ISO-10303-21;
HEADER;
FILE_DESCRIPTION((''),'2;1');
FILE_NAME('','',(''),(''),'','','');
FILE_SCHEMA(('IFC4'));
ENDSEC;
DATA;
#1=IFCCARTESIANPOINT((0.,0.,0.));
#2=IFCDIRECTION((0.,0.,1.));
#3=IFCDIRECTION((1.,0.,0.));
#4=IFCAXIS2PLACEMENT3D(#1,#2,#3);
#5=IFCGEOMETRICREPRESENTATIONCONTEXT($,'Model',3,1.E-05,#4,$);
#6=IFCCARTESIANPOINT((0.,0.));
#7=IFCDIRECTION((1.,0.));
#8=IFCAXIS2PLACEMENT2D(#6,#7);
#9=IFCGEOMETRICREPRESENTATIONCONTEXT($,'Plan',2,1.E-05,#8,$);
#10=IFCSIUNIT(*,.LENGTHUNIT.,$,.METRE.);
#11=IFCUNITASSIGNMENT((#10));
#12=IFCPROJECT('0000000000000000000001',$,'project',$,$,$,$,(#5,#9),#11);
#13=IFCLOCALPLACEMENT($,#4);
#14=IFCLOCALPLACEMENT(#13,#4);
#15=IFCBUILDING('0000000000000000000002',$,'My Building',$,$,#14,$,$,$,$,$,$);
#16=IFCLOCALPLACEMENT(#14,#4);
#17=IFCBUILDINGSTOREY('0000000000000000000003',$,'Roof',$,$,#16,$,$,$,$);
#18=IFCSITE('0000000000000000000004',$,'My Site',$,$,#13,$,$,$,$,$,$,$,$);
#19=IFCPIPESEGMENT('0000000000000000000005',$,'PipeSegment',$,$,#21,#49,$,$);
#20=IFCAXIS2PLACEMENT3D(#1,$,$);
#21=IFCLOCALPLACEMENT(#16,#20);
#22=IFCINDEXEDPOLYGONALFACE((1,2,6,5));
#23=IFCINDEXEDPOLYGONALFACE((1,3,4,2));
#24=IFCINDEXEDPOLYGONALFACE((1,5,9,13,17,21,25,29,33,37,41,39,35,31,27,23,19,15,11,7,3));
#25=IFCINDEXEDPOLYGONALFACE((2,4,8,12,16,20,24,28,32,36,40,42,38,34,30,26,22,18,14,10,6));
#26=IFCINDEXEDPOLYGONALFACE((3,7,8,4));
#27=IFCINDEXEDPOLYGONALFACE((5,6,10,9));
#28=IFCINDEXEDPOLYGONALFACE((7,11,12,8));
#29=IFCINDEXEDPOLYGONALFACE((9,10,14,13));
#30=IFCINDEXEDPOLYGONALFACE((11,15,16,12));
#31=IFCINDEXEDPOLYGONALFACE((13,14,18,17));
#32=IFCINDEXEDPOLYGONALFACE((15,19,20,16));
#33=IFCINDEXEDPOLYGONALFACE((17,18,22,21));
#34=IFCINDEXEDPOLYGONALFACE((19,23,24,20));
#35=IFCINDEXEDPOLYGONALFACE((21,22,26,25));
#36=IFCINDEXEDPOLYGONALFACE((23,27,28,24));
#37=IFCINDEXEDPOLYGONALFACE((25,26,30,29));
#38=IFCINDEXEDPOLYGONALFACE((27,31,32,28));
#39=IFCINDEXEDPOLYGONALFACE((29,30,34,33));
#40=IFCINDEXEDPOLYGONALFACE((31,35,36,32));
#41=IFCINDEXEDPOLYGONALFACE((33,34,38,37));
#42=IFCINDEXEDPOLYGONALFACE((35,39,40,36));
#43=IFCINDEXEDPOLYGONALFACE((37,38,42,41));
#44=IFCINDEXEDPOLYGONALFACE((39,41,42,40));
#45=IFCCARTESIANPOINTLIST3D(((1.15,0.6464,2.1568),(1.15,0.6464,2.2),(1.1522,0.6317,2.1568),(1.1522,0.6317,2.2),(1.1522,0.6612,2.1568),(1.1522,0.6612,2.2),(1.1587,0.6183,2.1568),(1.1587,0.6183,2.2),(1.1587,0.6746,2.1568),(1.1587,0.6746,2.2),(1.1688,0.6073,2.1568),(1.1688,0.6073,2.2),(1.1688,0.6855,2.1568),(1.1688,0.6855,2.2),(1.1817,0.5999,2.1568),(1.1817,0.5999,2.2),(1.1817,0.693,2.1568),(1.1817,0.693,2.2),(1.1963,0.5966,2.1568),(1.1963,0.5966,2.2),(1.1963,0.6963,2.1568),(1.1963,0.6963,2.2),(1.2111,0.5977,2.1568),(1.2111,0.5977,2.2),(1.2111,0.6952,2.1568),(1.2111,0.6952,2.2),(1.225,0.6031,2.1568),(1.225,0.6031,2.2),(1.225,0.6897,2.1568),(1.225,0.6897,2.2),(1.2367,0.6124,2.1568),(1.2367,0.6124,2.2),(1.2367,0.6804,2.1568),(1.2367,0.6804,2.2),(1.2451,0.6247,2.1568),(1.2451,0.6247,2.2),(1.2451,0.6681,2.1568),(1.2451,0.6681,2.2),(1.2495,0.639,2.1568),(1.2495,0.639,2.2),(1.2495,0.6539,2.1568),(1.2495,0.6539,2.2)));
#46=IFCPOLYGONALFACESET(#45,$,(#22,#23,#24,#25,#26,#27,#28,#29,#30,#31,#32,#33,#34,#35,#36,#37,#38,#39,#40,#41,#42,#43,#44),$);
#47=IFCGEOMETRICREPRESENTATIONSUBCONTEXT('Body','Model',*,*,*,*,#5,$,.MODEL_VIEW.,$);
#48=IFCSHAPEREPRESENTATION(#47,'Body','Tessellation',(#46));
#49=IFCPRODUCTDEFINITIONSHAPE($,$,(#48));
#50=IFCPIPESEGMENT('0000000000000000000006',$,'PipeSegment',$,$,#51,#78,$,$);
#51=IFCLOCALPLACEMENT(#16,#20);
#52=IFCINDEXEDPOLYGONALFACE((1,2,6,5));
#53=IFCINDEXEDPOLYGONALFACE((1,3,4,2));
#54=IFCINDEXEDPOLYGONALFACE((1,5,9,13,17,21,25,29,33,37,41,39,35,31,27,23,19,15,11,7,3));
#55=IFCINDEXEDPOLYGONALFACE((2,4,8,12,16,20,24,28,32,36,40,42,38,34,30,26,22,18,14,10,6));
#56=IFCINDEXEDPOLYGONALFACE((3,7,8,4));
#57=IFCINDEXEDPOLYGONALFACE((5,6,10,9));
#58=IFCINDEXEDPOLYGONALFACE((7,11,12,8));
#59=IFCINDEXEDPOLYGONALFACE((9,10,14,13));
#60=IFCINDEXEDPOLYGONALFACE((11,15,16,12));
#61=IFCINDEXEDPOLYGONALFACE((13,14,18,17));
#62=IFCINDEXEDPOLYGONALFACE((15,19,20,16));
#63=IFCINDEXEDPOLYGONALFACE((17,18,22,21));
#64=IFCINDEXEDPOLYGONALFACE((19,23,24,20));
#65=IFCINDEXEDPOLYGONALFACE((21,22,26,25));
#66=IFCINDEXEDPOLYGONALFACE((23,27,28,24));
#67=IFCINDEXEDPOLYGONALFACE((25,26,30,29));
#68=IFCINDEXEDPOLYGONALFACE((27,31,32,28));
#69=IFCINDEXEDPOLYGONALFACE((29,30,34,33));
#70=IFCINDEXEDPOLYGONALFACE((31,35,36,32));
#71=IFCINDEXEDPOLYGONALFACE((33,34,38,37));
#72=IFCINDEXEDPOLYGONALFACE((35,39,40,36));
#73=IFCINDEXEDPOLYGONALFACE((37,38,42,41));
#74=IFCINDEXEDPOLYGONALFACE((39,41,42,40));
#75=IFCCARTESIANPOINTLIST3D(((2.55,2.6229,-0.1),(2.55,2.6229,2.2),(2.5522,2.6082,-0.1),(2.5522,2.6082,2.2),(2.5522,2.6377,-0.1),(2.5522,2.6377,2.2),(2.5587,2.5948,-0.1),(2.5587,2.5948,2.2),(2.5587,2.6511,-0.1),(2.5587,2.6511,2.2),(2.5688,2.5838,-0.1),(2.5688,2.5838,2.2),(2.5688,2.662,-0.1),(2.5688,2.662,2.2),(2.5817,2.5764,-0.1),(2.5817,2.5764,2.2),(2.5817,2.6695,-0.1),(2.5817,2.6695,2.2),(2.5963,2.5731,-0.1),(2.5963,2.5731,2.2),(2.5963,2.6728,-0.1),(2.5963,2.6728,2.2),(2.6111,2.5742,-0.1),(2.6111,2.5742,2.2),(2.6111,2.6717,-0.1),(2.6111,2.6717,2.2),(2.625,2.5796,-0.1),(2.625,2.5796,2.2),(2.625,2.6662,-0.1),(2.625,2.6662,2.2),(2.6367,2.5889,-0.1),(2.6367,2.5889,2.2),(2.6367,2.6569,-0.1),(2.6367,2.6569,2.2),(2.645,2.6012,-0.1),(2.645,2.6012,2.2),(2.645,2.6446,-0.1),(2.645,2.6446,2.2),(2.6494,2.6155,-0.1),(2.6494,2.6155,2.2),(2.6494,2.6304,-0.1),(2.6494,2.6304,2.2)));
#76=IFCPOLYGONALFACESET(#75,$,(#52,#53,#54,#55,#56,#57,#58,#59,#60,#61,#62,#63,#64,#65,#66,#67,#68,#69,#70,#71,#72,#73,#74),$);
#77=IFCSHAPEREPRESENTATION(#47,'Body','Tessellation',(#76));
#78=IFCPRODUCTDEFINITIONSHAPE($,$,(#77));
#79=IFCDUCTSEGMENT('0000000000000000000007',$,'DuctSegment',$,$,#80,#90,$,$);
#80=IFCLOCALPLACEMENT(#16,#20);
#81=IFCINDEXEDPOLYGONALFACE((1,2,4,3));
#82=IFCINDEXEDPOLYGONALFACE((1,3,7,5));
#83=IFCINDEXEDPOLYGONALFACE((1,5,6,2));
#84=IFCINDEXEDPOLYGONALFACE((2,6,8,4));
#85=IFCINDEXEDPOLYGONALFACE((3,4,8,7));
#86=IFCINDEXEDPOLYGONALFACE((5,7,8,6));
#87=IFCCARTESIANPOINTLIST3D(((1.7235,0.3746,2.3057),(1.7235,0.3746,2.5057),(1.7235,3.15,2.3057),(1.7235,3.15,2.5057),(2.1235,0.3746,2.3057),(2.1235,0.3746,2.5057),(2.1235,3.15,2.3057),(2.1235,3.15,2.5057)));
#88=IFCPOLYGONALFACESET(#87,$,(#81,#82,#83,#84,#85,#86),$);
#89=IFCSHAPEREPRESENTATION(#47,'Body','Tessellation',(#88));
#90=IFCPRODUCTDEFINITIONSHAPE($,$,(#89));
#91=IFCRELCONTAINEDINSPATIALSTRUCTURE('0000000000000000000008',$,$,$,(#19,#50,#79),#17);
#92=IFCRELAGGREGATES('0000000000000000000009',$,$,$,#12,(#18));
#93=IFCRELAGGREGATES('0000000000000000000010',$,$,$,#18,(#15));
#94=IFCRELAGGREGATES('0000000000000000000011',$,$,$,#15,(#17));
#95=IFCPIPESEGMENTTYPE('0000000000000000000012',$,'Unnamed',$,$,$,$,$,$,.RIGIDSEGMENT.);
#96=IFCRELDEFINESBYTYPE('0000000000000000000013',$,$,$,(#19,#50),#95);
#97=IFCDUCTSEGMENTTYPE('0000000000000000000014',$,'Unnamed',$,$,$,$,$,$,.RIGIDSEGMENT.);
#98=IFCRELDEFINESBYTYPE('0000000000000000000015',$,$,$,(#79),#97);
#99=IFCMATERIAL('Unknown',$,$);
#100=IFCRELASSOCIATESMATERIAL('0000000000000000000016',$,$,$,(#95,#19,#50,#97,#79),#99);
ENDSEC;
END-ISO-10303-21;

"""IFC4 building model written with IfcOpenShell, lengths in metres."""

from ifc_helpers import new_model, si_unit, frame, origin_with_axes, origin_2d_with_axis, place, context, subcontext, project, spatial, rectangle, circle, extrude, material, material_profile, profile_set, profile_usage, type_object, element, save


model = new_model("IFC4")

# Units and contexts
model_context = context("Model", 3, precision=1e-05, world=origin_with_axes())
plan_context = context("Plan", 2, precision=1e-05, world=origin_2d_with_axis())
body_context = subcontext(model_context, "Body", "Model", "MODEL_VIEW")
ifc_project = project(units=[si_unit("LENGTHUNIT", "METRE")], contexts=[model_context, plan_context])

# Site, building, storey
site_placement = place(None, origin_with_axes())
site = spatial("IfcSite", under=ifc_project, at=site_placement, Name="My Site")
building_placement = place(site_placement, origin_with_axes())
building = spatial("IfcBuilding", under=site, at=building_placement, Name="My Building")
storey_placement = place(building_placement, origin_with_axes())
storey = spatial("IfcBuildingStorey", under=building, at=storey_placement, Name="Roof")

# Shared definitions
ifc_material = material(Name="Unknown")

# Pipe segments
ifc_material_profile_1 = material_profile(ifc_material, circle(Radius=0.05))
ifc_profile_set_1 = profile_set([ifc_material_profile_1])
pipe_segment_type = type_object("IfcPipeSegmentType", Name="Unnamed", PredefinedType="RIGIDSEGMENT", material=ifc_profile_set_1)
ifc_profile_usage_1 = profile_usage(ifc_profile_set_1, cardinal=5)
pipe_segment_1_placement = place(storey_placement, frame((1.2, 0.6464, 2.2), z_axis=(0.0, 0.0, -1.0), x_axis=(-1.0, 0.0, 0.0)))
element("IfcPipeSegment", 1, at=pipe_segment_1_placement, inside=storey, type_object=pipe_segment_type, material=ifc_profile_usage_1, Name="PipeSegment", context=body_context, shape_type="SweptSolid", body=[
    extrude(circle(Radius=0.05), origin_with_axes(), (0.0, 0.0, 1.0), 0.0432),
])
ifc_profile_usage_2 = profile_usage(ifc_profile_set_1, cardinal=5)
pipe_segment_2_placement = place(storey_placement, frame((2.6, 2.6229, 2.2), z_axis=(0.0, 0.0, -1.0), x_axis=(-1.0, 0.0, 0.0)))
element("IfcPipeSegment", 2, at=pipe_segment_2_placement, inside=storey, type_object=pipe_segment_type, material=ifc_profile_usage_2, Name="PipeSegment", context=body_context, shape_type="SweptSolid", body=[
    extrude(circle(Radius=0.05), origin_with_axes(), (0.0, 0.0, 1.0), 2.3),
])

# Duct segment
ifc_material_profile_2 = material_profile(ifc_material, rectangle(XDim=0.4, YDim=0.2))
ifc_profile_set_2 = profile_set([ifc_material_profile_2])
ifc_profile_usage_3 = profile_usage(ifc_profile_set_2, cardinal=5)
duct_segment_type = type_object("IfcDuctSegmentType", Name="Unnamed", PredefinedType="RIGIDSEGMENT", material=ifc_profile_set_2)
duct_segment_placement = place(storey_placement, frame((1.9235, 0.3746, 2.4057), z_axis=(0.0, 1.0, 0.0), x_axis=(-1.0, 0.0, 0.0)))
element("IfcDuctSegment", 3, at=duct_segment_placement, inside=storey, type_object=duct_segment_type, material=ifc_profile_usage_3, Name="DuctSegment", context=body_context, shape_type="SweptSolid", body=[
    extrude(rectangle(XDim=0.4, YDim=0.2), origin_with_axes(), (0.0, 0.0, 1.0), 2.7754),
])

save(model, "model.ifc")
